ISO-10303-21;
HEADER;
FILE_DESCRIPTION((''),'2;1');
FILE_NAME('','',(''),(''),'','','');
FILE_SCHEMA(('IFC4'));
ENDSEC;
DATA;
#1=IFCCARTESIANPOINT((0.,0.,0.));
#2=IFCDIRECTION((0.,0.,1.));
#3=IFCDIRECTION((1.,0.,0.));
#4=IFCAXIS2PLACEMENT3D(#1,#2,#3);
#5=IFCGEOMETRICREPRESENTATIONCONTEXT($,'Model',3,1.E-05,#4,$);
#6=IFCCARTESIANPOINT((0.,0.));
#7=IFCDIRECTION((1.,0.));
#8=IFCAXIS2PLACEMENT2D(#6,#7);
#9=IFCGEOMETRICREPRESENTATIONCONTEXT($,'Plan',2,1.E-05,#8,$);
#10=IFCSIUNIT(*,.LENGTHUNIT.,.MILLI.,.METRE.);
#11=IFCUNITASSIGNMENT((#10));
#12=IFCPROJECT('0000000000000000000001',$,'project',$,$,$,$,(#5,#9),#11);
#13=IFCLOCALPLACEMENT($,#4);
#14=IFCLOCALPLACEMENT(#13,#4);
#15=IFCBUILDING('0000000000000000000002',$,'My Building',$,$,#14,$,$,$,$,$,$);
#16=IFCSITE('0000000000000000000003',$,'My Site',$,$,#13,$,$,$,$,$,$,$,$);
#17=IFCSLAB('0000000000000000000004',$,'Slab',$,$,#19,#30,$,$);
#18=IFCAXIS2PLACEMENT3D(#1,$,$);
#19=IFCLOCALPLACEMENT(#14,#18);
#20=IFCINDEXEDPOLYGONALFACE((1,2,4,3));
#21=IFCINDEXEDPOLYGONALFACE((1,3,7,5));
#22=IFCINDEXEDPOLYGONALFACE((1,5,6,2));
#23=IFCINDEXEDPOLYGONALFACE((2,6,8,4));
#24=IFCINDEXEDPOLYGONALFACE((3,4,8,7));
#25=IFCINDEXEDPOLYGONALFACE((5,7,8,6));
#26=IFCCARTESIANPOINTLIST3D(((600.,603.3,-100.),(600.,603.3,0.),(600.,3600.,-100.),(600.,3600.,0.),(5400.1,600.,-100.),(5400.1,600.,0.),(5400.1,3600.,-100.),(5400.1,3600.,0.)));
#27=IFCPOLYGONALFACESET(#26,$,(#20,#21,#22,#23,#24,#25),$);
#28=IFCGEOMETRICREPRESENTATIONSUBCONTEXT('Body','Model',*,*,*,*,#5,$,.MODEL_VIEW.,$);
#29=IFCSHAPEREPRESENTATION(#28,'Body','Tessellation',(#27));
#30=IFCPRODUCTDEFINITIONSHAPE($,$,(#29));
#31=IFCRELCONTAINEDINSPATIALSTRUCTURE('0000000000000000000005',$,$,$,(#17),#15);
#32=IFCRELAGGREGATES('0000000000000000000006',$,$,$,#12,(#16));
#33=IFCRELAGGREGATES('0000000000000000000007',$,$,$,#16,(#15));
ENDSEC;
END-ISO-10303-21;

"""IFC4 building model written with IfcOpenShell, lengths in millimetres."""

from ifc_helpers import new_model, si_unit, frame, origin_with_axes, origin_2d_with_axis, place, context, subcontext, project, spatial, indexed_curve, outline, extrude, element, save


model = new_model("IFC4")

# Units and contexts
model_context = context("Model", 3, precision=1e-05, world=origin_with_axes())
plan_context = context("Plan", 2, precision=1e-05, world=origin_2d_with_axis())
body_context = subcontext(model_context, "Body", "Model", "MODEL_VIEW")
ifc_project = project(units=[si_unit("LENGTHUNIT", "METRE", prefix="MILLI")], contexts=[model_context, plan_context])

# Site, building
site_placement = place(None, origin_with_axes())
site = spatial("IfcSite", under=ifc_project, at=site_placement, Name="My Site")
building_placement = place(site_placement, origin_with_axes())
building = spatial("IfcBuilding", under=site, at=building_placement, Name="My Building")

# Slab
slab_placement = place(building_placement, frame((600.0, 603.3, 0.0), z_axis=(0.0, 0.0, 1.0), x_axis=(1.0, 0.0, 0.0)))
element("IfcSlab", 1, at=slab_placement, inside=building, Name="Slab", context=body_context, shape_type="SweptSolid", body=[
    extrude(outline(indexed_curve([(0.0, 0.0), (0.0, 2996.7), (4800.1, 2996.7), (4800.1, -3.3), (0.0, 0.0)])), frame((0.0, 0.0, -100.0), z_axis=(0.0, 0.0, 1.0), x_axis=(1.0, 0.0, 0.0)), (0.0, 0.0, 1.0), 100.0),
])

save(model, "model.ifc")
